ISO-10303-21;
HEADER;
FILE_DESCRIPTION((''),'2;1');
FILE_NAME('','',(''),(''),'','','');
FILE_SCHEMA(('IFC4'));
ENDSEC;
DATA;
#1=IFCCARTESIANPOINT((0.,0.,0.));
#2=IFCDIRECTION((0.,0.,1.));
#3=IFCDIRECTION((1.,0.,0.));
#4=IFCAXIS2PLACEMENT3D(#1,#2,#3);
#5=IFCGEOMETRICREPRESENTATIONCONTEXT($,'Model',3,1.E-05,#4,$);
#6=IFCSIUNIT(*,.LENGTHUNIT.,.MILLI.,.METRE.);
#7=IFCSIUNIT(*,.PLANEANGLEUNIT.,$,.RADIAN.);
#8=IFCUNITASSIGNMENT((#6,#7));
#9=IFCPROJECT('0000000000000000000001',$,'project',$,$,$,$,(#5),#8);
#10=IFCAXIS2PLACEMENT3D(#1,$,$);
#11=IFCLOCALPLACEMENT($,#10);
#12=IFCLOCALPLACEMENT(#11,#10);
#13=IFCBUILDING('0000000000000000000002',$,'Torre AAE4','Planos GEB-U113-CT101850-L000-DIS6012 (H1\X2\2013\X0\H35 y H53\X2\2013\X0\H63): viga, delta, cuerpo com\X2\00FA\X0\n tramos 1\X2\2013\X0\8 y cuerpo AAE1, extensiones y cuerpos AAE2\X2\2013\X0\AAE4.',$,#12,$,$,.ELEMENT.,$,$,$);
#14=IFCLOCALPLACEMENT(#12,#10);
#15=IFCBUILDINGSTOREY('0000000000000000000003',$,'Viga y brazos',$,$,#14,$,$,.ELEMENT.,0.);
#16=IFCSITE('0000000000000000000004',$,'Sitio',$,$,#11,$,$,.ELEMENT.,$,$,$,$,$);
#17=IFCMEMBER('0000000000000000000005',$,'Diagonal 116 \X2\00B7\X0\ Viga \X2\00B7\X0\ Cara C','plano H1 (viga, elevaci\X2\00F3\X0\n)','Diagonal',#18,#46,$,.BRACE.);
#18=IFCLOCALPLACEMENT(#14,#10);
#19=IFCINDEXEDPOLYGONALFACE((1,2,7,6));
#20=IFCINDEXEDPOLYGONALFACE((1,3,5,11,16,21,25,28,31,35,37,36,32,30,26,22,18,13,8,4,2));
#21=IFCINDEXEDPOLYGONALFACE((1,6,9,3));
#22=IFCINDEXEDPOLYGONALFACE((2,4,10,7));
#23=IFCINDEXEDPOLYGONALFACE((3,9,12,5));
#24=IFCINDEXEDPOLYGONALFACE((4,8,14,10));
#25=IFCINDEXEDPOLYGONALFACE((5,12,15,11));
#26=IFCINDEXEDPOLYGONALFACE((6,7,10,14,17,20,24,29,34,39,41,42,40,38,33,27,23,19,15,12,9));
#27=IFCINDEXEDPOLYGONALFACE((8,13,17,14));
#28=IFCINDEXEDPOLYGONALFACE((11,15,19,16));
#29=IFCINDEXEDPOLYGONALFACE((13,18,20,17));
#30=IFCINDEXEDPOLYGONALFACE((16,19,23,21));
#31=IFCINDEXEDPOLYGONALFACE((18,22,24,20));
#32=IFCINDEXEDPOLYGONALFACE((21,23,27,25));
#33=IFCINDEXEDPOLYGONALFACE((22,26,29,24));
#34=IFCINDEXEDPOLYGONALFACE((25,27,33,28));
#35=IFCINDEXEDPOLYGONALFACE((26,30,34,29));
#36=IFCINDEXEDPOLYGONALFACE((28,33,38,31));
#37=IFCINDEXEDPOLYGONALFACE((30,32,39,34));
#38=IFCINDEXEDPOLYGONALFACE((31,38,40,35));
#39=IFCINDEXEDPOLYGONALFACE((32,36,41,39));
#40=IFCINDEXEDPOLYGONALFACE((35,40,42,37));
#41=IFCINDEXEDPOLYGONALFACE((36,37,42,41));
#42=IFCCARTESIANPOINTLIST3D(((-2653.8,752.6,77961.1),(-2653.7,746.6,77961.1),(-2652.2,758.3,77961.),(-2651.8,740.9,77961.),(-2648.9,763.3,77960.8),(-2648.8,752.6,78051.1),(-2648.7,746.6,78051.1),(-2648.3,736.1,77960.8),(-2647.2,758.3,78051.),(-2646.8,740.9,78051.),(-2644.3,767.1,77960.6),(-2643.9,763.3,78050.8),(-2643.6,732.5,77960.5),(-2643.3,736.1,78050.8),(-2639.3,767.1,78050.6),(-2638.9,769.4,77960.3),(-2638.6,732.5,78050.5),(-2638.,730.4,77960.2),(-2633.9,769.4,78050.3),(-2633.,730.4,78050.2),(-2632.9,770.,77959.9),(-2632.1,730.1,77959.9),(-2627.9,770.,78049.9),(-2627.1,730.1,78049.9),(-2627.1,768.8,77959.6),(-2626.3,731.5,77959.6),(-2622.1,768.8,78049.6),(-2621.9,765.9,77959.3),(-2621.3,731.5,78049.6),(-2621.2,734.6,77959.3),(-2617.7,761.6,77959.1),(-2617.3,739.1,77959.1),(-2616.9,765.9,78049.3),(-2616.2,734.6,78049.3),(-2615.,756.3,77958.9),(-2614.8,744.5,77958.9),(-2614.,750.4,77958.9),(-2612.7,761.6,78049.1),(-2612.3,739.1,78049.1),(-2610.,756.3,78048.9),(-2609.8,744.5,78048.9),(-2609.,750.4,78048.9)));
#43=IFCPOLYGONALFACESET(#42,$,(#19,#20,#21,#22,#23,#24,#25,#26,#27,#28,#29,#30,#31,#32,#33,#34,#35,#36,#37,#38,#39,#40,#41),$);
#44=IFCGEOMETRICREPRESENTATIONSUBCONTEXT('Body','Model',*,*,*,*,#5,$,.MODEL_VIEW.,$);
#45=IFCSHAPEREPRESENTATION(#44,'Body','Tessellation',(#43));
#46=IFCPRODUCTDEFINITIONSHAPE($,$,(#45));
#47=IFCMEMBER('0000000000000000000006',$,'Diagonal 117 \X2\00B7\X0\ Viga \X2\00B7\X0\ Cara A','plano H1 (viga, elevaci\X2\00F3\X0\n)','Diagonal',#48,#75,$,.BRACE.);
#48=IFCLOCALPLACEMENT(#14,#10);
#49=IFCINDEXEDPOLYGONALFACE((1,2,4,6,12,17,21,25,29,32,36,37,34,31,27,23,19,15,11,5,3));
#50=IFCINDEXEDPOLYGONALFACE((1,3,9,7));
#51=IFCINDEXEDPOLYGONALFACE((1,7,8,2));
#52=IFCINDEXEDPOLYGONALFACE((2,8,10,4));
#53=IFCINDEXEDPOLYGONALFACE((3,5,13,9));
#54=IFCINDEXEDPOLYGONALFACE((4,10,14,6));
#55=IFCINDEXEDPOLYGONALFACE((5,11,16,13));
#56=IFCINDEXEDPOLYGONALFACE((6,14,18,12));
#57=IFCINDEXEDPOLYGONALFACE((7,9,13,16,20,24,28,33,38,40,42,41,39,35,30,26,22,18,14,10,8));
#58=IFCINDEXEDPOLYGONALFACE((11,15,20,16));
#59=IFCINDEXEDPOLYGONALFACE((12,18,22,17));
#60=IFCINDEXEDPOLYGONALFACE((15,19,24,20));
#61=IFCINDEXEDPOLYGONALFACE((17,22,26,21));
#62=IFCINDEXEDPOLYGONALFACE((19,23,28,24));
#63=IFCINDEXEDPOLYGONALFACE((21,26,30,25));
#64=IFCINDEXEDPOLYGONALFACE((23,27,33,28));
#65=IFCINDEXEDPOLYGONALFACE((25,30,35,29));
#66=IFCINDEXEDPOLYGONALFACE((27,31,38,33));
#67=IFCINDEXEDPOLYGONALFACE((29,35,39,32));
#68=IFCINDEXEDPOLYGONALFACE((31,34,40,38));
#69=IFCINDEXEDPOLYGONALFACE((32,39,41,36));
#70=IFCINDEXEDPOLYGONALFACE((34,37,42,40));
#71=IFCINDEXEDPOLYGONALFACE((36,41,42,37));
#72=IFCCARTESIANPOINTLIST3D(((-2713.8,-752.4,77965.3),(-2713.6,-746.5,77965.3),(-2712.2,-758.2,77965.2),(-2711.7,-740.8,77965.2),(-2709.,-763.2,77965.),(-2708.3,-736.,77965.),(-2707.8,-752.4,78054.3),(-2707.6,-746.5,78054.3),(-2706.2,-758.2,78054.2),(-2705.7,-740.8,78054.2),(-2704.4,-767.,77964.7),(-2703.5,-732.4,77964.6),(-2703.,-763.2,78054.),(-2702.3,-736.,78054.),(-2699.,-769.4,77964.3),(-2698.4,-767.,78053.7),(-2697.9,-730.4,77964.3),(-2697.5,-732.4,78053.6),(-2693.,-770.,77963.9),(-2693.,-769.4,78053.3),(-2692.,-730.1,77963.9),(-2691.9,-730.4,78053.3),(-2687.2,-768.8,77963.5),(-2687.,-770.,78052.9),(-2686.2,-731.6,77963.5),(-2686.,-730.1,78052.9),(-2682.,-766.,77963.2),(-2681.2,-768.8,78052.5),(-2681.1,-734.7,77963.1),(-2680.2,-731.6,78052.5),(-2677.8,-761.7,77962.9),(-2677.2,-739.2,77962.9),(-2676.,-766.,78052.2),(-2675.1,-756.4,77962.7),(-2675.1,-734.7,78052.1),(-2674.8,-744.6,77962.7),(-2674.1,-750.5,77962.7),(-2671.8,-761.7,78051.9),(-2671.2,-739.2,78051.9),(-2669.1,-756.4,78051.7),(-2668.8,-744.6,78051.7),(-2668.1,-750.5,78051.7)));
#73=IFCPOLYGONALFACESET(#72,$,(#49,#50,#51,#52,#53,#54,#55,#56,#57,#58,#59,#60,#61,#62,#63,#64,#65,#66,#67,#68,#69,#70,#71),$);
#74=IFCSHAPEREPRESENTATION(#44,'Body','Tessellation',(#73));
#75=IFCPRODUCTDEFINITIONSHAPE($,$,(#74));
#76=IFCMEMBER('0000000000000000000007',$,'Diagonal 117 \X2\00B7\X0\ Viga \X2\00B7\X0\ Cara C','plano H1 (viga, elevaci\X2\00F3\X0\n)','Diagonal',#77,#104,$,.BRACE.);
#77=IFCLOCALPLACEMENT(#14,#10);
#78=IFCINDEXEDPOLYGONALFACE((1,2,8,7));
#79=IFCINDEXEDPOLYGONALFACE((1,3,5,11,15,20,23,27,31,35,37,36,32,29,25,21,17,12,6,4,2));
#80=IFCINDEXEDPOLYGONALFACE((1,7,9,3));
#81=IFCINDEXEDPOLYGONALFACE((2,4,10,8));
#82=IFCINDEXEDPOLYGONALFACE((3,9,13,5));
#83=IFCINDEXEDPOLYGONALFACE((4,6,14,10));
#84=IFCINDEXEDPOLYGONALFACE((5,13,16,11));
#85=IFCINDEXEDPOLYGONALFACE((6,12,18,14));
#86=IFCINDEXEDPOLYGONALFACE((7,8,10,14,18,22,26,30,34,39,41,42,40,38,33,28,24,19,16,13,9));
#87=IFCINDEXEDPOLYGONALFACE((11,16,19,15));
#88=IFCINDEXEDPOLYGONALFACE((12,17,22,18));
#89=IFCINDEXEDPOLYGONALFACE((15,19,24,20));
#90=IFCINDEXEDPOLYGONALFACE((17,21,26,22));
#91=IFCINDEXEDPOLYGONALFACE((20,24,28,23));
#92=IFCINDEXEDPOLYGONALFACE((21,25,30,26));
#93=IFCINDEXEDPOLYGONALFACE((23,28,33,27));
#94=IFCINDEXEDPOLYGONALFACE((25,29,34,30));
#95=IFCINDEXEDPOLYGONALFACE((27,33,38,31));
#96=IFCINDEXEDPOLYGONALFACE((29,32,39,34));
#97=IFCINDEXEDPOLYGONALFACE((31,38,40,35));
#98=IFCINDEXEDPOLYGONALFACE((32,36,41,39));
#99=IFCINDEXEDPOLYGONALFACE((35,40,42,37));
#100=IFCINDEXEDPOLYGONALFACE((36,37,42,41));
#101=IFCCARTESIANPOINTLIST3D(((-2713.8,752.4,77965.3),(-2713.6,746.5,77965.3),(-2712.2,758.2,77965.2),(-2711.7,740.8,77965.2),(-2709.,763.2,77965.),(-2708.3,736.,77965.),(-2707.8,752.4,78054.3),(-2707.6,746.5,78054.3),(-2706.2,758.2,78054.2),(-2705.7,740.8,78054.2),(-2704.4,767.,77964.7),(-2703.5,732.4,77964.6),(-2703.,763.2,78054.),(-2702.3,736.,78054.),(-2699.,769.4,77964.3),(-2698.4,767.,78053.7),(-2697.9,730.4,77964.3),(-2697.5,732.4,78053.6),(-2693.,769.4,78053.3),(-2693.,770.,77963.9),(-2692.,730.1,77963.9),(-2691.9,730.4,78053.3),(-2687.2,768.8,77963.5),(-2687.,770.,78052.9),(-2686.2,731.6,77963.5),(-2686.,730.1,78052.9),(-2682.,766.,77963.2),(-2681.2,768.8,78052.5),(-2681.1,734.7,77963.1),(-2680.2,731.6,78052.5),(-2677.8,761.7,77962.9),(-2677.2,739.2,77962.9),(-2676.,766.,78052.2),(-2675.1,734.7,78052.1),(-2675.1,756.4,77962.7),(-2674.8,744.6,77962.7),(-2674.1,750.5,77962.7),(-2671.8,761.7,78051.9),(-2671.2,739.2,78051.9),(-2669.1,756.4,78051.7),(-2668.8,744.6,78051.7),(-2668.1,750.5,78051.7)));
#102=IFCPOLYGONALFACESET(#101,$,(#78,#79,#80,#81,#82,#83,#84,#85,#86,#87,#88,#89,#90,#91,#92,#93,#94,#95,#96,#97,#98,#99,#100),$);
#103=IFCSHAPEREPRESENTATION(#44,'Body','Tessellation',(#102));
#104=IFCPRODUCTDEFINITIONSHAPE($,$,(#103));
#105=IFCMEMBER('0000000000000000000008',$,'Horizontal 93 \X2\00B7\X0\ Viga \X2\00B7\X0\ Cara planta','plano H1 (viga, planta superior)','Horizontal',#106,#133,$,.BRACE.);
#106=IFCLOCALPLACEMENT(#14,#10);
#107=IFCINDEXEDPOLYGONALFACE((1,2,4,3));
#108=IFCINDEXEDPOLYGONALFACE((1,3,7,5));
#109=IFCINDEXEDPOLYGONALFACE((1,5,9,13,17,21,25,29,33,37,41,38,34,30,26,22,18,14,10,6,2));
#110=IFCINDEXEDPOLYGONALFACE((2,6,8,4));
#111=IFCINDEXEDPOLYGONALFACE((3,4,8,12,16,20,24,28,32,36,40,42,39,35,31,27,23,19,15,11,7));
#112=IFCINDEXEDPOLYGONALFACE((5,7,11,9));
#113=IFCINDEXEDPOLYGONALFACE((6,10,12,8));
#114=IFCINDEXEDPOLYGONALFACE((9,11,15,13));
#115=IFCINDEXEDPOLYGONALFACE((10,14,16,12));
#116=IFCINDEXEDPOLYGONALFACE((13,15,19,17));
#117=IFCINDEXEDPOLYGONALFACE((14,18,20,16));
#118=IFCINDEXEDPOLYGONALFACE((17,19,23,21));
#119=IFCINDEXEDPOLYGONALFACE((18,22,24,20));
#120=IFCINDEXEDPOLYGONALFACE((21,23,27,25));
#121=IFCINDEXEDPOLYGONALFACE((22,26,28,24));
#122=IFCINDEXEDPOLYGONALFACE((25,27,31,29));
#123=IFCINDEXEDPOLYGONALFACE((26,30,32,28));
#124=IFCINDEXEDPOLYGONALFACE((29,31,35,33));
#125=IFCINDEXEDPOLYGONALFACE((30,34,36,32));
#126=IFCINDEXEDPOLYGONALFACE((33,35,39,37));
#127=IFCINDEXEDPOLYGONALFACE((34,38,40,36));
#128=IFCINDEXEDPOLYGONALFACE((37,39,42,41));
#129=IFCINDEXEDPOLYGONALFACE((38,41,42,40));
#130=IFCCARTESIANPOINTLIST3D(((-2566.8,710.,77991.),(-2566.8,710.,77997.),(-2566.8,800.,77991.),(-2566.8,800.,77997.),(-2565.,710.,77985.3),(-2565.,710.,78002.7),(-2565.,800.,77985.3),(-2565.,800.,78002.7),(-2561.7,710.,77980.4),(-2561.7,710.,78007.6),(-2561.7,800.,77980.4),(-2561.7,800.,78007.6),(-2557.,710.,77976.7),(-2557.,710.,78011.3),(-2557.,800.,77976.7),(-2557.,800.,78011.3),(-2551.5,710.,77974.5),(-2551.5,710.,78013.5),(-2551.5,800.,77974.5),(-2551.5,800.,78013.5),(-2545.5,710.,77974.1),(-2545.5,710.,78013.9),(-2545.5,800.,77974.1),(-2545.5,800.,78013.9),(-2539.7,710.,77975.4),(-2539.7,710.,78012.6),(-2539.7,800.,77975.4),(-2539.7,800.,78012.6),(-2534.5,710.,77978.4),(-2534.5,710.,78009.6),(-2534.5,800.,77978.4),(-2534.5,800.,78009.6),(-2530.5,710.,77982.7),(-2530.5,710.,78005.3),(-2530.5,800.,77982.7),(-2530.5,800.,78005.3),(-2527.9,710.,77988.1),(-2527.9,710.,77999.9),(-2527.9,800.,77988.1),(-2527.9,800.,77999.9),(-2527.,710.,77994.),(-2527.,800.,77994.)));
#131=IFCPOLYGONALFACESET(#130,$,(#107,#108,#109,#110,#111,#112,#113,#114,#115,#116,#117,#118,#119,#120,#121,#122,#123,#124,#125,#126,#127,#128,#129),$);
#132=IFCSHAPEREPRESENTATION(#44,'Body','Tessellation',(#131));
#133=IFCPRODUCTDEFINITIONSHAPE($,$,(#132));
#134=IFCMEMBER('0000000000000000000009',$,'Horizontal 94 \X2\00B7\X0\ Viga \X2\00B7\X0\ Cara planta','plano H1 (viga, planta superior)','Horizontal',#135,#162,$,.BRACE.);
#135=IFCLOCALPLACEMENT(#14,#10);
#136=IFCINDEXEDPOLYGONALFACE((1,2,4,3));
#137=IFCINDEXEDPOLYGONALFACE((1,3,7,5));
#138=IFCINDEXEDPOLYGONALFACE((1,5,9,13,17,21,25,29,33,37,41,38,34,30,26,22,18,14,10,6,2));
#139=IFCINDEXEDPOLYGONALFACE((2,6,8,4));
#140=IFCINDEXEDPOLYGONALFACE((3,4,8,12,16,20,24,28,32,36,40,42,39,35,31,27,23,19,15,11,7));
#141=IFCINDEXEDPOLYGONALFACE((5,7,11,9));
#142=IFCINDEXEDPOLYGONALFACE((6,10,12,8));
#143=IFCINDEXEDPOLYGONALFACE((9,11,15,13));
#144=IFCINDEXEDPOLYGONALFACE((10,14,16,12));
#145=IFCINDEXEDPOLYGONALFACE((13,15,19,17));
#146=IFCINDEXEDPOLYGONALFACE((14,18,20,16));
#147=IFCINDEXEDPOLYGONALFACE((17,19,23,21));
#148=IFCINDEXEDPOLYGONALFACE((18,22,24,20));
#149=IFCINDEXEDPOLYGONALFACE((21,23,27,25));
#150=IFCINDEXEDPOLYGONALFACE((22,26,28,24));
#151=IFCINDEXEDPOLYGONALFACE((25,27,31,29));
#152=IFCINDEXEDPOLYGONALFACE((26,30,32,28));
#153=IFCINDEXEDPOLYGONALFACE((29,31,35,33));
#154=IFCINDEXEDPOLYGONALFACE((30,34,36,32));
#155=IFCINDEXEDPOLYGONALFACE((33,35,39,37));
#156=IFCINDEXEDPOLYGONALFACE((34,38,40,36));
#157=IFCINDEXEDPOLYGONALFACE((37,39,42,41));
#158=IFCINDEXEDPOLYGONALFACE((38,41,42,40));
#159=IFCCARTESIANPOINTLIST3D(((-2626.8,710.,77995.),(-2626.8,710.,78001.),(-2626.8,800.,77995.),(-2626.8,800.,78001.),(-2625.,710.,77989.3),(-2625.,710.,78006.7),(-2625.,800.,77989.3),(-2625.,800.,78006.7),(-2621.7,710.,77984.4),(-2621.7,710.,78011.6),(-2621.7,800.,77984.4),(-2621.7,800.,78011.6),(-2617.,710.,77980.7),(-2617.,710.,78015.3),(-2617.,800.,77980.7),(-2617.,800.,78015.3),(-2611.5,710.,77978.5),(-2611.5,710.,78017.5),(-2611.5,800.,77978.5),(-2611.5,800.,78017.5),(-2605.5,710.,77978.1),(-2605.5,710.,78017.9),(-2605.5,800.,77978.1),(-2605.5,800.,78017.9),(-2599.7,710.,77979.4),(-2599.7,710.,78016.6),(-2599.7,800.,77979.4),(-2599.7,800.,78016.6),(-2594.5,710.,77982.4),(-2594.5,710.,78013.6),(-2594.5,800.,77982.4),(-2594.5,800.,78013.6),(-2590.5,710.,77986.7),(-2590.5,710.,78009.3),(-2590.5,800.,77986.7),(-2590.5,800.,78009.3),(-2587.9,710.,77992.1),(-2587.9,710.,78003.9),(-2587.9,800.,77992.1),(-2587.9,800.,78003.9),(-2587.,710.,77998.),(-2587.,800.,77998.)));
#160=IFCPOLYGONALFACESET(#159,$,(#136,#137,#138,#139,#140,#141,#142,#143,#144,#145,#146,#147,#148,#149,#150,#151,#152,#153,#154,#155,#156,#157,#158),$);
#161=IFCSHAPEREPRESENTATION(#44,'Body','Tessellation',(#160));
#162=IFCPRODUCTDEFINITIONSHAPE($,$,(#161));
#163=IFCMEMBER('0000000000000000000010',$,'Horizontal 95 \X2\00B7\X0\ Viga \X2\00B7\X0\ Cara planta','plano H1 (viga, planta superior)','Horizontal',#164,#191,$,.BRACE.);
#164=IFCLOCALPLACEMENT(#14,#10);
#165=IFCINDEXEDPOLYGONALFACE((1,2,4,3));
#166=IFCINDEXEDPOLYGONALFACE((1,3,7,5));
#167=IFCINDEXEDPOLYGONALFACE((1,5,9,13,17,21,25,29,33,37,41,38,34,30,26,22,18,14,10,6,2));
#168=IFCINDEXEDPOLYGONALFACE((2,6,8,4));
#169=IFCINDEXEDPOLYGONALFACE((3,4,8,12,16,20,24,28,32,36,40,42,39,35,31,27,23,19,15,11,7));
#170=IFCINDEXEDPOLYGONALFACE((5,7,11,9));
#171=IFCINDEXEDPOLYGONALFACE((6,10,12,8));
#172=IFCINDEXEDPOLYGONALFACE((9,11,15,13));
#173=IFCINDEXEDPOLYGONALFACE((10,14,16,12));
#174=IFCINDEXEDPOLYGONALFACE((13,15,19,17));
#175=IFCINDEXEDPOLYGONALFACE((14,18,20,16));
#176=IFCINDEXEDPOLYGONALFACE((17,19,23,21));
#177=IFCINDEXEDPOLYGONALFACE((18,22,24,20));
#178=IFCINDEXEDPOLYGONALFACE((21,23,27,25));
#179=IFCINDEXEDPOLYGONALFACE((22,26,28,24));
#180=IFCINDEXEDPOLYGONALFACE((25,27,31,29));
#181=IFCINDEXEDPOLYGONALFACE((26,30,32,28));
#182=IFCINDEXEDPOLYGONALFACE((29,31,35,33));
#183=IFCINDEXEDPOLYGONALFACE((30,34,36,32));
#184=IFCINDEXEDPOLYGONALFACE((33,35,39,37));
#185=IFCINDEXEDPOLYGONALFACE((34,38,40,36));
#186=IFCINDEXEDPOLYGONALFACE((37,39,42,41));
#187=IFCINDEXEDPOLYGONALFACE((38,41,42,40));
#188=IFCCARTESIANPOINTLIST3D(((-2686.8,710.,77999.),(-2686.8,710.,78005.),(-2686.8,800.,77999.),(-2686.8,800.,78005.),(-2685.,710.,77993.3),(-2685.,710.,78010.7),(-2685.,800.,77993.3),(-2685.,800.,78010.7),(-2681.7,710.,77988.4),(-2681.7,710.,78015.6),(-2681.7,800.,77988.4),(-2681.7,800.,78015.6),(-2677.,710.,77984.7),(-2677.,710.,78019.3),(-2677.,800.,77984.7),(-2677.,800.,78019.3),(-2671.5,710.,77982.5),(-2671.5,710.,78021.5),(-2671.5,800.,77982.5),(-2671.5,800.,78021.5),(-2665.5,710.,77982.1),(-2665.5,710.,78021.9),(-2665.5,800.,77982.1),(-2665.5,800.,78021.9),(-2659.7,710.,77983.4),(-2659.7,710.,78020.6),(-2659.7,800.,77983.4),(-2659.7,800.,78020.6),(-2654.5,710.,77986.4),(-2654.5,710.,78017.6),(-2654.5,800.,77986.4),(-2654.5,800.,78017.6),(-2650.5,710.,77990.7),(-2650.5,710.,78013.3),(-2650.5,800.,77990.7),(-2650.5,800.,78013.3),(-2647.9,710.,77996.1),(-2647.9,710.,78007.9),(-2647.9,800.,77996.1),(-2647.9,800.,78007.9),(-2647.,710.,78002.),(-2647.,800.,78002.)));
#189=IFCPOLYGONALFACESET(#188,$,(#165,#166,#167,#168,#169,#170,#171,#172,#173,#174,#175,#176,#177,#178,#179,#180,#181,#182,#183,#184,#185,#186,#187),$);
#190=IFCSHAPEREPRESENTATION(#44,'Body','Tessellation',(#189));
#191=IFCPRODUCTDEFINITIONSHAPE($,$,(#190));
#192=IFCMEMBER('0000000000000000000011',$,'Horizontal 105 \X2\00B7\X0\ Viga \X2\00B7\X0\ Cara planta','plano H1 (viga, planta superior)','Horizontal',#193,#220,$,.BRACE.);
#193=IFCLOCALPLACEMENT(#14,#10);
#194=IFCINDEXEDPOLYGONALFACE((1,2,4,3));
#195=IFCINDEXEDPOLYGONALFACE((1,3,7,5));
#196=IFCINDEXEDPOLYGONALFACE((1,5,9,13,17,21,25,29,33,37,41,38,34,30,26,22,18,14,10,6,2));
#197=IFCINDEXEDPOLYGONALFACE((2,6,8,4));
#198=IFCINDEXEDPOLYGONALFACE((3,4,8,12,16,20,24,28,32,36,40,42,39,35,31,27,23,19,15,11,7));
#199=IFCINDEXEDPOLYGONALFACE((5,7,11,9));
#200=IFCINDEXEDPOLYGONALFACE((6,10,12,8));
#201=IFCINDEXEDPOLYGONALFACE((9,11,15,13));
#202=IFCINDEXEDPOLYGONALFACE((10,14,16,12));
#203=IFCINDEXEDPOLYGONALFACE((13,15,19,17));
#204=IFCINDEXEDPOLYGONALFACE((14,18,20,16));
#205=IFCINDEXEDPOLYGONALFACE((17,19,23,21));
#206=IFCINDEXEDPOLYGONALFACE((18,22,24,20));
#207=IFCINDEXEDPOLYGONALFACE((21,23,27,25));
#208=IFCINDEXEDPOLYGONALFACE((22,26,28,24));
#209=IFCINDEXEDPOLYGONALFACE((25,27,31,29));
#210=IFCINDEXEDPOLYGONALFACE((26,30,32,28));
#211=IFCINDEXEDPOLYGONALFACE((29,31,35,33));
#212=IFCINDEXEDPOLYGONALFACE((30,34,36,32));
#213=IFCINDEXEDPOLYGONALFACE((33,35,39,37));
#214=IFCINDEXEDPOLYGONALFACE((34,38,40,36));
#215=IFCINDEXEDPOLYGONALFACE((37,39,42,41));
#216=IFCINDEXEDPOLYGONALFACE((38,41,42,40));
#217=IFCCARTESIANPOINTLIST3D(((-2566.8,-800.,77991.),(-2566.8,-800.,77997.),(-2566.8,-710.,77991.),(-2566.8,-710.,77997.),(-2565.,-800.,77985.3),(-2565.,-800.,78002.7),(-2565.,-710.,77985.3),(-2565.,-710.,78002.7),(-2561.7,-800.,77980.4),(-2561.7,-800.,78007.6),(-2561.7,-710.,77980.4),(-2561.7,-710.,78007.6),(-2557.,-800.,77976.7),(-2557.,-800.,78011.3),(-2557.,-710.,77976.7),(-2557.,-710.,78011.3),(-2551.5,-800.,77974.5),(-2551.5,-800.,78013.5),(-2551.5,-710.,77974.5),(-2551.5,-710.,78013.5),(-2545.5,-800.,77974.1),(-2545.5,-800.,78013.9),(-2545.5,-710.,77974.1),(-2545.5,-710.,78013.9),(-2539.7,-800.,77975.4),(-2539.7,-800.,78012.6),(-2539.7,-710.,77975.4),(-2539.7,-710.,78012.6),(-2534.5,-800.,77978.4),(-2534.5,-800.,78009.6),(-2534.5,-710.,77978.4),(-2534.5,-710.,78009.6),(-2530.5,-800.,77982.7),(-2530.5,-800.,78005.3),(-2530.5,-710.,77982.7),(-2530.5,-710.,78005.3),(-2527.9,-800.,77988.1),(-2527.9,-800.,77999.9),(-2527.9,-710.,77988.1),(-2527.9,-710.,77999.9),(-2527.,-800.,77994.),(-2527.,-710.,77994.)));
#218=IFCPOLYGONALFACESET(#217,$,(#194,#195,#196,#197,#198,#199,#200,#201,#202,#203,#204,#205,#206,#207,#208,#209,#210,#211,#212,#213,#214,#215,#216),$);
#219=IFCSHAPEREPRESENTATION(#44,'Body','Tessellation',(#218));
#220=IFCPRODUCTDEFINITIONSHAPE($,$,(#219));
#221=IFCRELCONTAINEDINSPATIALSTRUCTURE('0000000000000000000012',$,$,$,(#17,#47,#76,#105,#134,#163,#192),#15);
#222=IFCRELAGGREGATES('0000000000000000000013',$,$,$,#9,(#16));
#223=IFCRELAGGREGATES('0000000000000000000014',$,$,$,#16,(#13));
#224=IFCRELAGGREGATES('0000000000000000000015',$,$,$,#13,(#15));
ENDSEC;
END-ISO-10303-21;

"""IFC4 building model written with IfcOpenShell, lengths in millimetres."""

from ifc_helpers import new_model, si_unit, frame, origin, origin_with_axes, place, context, subcontext, project, spatial, circle, extrude, element, save


model = new_model("IFC4")

# Units and contexts
model_context = context("Model", 3, precision=1e-05, world=origin_with_axes())
body_context = subcontext(model_context, "Body", "Model", "MODEL_VIEW")
ifc_project = project(units=[si_unit("LENGTHUNIT", "METRE", prefix="MILLI"), si_unit("PLANEANGLEUNIT", "RADIAN")], contexts=[model_context])

# Site, building, storey
site_placement = place(None, origin())
site = spatial("IfcSite", under=ifc_project, at=site_placement, Name="Sitio", CompositionType="ELEMENT")
building_placement = place(site_placement, origin())
building = spatial("IfcBuilding", under=site, at=building_placement, Name="Torre AAE4", Description="Planos GEB-U113-CT101850-L000-DIS6012 (H1–H35 y H53–H63): viga, delta, cuerpo común tramos 1–8 y cuerpo AAE1, extensiones y cuerpos AAE2–AAE4.", CompositionType="ELEMENT")
storey_placement = place(building_placement, origin())
storey = spatial("IfcBuildingStorey", under=building, at=storey_placement, Name="Viga y brazos", CompositionType="ELEMENT", Elevation=0.0)

# Members
for number, where, z_axis, x_axis, name in (
    (1, (-2634.0, 750.0, 77960.0), (0.05547, 0.0, 0.99846), (0.960111, -0.274484, -0.05334), "Diagonal 116 · Viga · Cara C"),
):
    element("IfcMember", number, at=place(storey_placement, frame(where, z_axis=z_axis, x_axis=x_axis)), inside=storey, Name=name, Description="plano H1 (viga, elevación)", ObjectType="Diagonal", PredefinedType="BRACE", context=body_context, shape_type="SweptSolid", body=[
        extrude(circle(Radius=20.0), None, (0.0, 0.0, 1.0), 90.1),
    ])
for number, where, z_axis, x_axis, name in (
    (2, (-2694.0, -750.0, 77964.0), (0.067263, 0.0, 0.997735), (0.960948, 0.26904, -0.064783), "Diagonal 117 · Viga · Cara A"),
    (3, (-2694.0, 750.0, 77964.0), (0.067263, 0.0, 0.997735), (0.960948, -0.26904, -0.064783), "Diagonal 117 · Viga · Cara C"),
):
    element("IfcMember", number, at=place(storey_placement, frame(where, z_axis=z_axis, x_axis=x_axis)), inside=storey, Name=name, Description="plano H1 (viga, elevación)", ObjectType="Diagonal", PredefinedType="BRACE", context=body_context, shape_type="SweptSolid", body=[
        extrude(circle(Radius=20.0), None, (0.0, 0.0, 1.0), 89.2),
    ])
for number, where, z_axis, x_axis, name in (
    (4, (-2547.0, 710.0, 77994.0), (0.0, 1.0, 0.0), (1.0, 0.0, 0.0), "Horizontal 93 · Viga · Cara planta"),
    (5, (-2607.0, 710.0, 77998.0), (0.0, 1.0, 0.0), (1.0, 0.0, 0.0), "Horizontal 94 · Viga · Cara planta"),
    (6, (-2667.0, 710.0, 78002.0), (0.0, 1.0, 0.0), (1.0, 0.0, 0.0), "Horizontal 95 · Viga · Cara planta"),
    (7, (-2547.0, -710.0, 77994.0), (0.0, -1.0, 0.0), (1.0, 0.0, 0.0), "Horizontal 105 · Viga · Cara planta"),
):
    element("IfcMember", number, at=place(storey_placement, frame(where, z_axis=z_axis, x_axis=x_axis)), inside=storey, Name=name, Description="plano H1 (viga, planta superior)", ObjectType="Horizontal", PredefinedType="BRACE", context=body_context, shape_type="SweptSolid", body=[
        extrude(circle(Radius=20.0), None, (0.0, 0.0, 1.0), 90.0),
    ])

save(model, "model.ifc")
